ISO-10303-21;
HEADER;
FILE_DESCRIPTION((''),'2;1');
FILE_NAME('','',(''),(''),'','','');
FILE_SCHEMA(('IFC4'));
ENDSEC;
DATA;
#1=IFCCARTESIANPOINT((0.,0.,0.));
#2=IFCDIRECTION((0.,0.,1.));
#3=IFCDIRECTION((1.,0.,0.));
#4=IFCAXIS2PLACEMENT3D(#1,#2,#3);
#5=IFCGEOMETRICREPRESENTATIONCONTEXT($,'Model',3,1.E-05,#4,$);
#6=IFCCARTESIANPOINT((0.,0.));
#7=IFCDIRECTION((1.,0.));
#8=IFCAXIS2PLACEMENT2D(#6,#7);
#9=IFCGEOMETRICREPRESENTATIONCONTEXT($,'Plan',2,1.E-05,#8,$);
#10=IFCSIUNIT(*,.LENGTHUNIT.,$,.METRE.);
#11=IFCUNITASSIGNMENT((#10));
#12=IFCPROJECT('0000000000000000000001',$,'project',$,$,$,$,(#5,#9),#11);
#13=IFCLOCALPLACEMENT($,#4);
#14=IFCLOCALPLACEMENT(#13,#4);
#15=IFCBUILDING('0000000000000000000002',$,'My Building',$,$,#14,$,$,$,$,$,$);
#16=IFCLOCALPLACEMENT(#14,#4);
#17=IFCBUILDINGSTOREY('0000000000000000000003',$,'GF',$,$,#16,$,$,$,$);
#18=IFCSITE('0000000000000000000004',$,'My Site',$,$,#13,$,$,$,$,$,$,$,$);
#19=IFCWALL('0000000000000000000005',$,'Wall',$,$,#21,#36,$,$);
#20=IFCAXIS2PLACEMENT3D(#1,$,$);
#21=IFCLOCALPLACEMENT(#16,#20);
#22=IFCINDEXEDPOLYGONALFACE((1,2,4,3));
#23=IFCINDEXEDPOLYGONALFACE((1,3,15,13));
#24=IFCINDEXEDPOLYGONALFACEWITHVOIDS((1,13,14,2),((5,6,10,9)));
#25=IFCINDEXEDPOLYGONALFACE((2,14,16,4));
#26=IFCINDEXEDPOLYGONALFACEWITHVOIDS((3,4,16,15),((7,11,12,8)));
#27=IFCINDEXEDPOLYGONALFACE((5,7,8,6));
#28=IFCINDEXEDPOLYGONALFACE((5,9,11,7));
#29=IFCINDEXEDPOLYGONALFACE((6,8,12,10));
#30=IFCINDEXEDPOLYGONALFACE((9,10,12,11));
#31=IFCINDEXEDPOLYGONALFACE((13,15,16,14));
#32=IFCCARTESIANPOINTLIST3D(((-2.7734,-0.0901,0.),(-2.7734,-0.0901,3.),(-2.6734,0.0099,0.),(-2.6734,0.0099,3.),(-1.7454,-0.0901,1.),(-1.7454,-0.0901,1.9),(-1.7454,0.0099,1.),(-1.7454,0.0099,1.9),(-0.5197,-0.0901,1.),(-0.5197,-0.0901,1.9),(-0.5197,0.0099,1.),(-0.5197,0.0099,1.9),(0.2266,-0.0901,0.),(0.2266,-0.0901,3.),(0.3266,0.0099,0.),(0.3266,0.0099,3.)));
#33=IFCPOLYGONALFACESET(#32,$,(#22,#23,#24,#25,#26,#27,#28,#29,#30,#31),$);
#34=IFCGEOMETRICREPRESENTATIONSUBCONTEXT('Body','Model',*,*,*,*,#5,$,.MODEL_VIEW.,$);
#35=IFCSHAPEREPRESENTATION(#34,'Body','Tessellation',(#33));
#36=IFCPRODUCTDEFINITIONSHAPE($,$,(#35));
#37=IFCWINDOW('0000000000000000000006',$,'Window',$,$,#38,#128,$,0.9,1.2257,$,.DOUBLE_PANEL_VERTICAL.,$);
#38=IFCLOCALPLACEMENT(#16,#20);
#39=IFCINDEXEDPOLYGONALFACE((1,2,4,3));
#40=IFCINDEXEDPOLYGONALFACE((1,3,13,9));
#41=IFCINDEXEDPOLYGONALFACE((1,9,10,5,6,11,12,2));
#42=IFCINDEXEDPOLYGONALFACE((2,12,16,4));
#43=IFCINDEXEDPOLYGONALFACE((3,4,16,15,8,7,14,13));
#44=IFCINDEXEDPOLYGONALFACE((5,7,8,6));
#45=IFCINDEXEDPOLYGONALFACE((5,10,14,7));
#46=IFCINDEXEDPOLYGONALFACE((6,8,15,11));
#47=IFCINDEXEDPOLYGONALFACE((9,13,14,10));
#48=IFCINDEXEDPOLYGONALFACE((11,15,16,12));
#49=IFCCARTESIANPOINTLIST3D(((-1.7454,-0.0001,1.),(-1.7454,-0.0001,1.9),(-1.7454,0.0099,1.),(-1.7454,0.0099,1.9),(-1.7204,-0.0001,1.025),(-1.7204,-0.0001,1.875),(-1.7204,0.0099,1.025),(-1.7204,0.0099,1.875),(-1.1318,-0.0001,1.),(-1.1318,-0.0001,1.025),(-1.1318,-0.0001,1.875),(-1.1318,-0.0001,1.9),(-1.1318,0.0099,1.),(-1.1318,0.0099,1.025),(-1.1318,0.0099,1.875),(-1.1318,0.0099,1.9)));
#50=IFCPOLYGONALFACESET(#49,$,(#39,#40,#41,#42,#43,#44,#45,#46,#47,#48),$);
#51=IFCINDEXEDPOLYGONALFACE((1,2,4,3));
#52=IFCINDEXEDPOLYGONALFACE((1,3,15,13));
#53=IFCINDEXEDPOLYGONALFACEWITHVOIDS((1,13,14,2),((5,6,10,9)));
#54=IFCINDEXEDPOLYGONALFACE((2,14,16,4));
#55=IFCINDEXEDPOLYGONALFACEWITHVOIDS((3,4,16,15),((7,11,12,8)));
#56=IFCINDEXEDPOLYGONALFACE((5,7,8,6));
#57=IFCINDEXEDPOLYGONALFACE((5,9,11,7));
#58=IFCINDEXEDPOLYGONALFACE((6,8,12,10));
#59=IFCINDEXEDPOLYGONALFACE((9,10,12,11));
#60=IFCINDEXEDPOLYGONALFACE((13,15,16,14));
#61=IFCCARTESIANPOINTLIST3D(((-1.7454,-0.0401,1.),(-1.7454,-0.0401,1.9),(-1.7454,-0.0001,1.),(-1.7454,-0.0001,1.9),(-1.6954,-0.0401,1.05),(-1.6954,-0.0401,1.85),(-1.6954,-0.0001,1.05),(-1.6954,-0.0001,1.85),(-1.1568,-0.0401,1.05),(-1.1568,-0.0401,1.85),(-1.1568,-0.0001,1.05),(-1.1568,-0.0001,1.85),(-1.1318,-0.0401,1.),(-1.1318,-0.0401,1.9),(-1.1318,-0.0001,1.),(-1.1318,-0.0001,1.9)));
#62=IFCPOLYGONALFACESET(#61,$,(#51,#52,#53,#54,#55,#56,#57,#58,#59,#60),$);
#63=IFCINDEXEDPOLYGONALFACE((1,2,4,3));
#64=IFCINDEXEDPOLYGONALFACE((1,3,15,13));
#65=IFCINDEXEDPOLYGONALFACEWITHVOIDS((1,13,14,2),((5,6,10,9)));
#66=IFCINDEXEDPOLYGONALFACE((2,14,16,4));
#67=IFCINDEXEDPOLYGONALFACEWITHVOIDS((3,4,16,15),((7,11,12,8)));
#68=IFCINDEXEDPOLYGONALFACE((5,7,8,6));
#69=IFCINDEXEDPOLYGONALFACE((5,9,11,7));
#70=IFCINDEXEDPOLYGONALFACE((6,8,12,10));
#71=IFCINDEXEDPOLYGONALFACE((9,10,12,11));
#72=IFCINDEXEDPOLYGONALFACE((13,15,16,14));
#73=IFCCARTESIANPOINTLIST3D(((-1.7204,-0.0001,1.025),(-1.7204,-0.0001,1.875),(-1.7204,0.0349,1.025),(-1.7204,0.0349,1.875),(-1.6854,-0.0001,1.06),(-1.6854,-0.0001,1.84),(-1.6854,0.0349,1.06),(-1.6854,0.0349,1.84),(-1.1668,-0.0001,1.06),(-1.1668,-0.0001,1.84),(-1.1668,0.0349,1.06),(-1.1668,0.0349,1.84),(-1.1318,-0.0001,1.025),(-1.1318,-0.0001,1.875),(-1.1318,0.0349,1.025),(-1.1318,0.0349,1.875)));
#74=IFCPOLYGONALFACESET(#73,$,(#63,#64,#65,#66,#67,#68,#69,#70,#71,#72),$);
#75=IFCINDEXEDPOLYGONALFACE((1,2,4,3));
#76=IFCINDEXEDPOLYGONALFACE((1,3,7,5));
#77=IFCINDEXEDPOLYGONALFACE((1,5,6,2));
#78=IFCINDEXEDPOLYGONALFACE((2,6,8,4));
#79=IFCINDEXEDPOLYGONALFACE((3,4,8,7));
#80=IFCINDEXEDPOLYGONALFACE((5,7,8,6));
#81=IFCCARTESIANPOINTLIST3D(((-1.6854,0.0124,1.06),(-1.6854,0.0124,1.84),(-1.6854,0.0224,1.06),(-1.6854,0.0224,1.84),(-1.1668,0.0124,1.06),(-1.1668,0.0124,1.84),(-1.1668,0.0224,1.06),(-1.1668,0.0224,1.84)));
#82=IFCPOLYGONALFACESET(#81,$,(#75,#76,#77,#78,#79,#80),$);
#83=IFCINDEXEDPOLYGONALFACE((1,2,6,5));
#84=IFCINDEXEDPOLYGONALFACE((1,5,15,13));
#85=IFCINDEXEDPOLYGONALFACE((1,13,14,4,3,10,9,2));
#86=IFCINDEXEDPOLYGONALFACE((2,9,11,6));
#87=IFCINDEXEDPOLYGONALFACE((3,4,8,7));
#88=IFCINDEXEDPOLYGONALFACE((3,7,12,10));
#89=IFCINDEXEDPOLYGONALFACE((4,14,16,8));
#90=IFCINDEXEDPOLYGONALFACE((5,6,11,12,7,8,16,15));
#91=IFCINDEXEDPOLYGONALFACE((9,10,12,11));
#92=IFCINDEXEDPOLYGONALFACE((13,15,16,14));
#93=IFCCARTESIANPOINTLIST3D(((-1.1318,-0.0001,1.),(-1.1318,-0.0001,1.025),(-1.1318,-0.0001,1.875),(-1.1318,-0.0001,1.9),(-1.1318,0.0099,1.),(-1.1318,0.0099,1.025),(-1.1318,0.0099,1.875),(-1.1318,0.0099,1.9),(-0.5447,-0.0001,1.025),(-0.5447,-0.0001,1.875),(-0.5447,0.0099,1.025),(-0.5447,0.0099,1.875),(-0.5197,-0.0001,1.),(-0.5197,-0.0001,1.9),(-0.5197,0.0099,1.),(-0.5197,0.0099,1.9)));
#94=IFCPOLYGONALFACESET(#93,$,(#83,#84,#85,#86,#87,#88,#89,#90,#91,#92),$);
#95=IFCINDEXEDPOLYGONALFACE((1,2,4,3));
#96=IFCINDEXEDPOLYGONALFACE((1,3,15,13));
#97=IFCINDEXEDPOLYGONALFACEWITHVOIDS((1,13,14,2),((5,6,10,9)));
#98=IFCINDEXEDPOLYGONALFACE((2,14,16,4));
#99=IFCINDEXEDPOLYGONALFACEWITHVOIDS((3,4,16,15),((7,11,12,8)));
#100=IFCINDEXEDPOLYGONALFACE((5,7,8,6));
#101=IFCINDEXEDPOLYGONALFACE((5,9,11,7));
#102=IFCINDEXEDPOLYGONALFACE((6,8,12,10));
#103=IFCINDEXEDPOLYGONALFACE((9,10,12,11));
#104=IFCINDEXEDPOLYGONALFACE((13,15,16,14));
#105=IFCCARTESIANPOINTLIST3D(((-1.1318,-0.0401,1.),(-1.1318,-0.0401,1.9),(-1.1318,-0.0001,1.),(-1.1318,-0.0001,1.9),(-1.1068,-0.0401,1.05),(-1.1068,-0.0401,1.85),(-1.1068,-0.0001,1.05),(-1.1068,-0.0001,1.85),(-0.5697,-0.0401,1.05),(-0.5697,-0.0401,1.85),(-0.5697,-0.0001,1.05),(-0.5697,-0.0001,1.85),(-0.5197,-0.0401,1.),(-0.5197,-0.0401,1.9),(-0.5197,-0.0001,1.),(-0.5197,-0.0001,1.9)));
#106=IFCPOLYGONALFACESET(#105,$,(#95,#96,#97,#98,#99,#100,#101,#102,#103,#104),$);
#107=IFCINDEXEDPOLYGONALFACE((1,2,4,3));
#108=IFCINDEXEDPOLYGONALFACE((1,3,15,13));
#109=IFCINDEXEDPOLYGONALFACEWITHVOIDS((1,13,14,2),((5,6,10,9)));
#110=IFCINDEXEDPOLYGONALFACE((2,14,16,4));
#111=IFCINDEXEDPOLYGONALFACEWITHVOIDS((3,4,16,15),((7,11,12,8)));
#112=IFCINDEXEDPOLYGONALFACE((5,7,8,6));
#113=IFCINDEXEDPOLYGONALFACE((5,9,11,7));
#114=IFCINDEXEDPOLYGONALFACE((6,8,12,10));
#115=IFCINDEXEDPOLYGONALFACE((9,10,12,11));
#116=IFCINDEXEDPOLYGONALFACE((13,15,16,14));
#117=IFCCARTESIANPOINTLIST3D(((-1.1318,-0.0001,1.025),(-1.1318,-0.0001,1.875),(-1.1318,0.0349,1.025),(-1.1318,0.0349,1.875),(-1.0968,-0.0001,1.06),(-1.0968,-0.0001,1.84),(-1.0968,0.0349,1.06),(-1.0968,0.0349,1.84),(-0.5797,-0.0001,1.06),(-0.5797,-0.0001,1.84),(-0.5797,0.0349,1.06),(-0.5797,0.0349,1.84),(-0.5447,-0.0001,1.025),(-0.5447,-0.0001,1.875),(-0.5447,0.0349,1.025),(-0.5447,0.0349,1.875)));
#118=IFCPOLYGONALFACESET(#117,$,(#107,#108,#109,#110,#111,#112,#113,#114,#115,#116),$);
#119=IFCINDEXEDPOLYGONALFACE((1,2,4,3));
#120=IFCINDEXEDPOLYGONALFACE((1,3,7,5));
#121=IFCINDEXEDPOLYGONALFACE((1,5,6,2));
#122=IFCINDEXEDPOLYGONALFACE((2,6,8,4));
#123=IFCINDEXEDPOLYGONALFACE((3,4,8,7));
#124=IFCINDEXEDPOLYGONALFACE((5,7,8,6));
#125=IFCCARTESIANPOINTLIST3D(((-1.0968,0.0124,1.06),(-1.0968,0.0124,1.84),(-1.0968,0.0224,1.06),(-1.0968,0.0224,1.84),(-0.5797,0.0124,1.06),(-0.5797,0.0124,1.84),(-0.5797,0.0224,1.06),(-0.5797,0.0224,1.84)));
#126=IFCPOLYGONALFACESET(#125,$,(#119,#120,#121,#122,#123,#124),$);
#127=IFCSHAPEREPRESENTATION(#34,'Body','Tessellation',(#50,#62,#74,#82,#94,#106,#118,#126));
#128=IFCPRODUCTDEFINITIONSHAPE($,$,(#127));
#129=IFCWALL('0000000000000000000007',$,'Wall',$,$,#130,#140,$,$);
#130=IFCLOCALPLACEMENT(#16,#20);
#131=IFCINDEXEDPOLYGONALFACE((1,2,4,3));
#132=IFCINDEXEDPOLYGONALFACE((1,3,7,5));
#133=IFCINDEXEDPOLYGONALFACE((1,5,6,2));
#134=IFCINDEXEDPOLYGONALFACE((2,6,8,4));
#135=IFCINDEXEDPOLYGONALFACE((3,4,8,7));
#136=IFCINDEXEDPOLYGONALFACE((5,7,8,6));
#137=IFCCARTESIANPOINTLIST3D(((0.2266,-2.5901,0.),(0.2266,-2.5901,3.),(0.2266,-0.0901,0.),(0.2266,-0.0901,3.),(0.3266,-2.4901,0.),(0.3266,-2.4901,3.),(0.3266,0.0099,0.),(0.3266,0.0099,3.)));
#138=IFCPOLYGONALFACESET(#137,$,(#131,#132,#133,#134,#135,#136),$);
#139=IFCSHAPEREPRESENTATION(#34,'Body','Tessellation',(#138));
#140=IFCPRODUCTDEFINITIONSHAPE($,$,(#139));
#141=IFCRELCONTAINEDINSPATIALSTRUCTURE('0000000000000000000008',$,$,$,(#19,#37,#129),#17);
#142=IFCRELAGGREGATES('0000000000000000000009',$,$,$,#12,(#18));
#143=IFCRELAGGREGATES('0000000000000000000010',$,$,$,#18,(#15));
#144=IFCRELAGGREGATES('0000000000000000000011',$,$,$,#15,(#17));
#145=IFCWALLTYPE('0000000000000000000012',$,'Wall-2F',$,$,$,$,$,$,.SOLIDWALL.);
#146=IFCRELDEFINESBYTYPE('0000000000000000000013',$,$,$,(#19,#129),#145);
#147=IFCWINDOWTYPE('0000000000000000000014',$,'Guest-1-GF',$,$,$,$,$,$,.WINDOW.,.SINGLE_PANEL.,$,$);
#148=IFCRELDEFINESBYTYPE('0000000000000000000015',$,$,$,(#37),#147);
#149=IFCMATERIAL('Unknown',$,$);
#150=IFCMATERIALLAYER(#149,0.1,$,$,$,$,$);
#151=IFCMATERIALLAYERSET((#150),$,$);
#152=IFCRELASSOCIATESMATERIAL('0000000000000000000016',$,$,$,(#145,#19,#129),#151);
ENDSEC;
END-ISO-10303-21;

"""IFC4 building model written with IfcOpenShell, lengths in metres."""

from ifc_helpers import new_model, entity, si_unit, frame, origin_with_axes, origin_2d_with_axis, place, context, subcontext, project, spatial, line, indexed_curve, outline, extrude, shape, source, transform, mapped, material, layer, layer_set, layer_usage, type_object, type_shapes, element, fill, save


model = new_model("IFC4")

# Units and contexts
model_context = context("Model", 3, precision=1e-05, world=origin_with_axes())
plan_context = context("Plan", 2, precision=1e-05, world=origin_2d_with_axis())
body_context_1 = subcontext(model_context, "Body", "Model", "MODEL_VIEW")
body_context_2 = subcontext(plan_context, "Body", "Plan", "PLAN_VIEW")
ifc_project = project(units=[si_unit("LENGTHUNIT", "METRE")], contexts=[model_context, plan_context])

# Site, building, storey
site_placement = place(None, origin_with_axes())
site = spatial("IfcSite", under=ifc_project, at=site_placement, Name="My Site")
building_placement = place(site_placement, origin_with_axes())
building = spatial("IfcBuilding", under=site, at=building_placement, Name="My Building")
storey_placement = place(building_placement, origin_with_axes())
storey = spatial("IfcBuildingStorey", under=building, at=storey_placement, Name="GF")

# Shared definitions
ifc_material = material(Name="Unknown")

# Shared definitions
ifc_layer_1 = layer(ifc_material, 0.1)
ifc_layer_set_1 = layer_set([ifc_layer_1])
wall_type = type_object("IfcWallType", Name="Wall-2F", PredefinedType="SOLIDWALL", material=ifc_layer_set_1)

# Wall, opening, window
ifc_layer_usage_1 = layer_usage(ifc_layer_set_1, "AXIS2", "POSITIVE", 0.0)
wall_1_placement = place(storey_placement, frame((-2.7734, -0.0901, 0.0), z_axis=(0.0, 0.0, 1.0), x_axis=(1.0, 0.0, 0.0)))
wall_1 = element("IfcWall", 1, at=wall_1_placement, inside=storey, type_object=wall_type, material=ifc_layer_usage_1, Name="Wall", context=body_context_1, shape_type="SweptSolid", body=[
    extrude(outline(indexed_curve([(0.0, 0.0), (0.1, 0.1), (3.1, 0.1), (3.0, 0.0)], segments=[line(1, 2, 3, 4, 1)])), origin_with_axes(), (0.0, 0.0, 1.0), 3.0),
])
shared_shape_1 = source(origin_with_axes(), body_context_1, "Body", "SweptSolid", [
    extrude(outline(indexed_curve([(0.0, 0.0), (1.2257, 0.0), (1.2257, 0.9), (0.0, 0.9)], segments=[line(1, 2, 3, 4, 1)])), frame((0.0, -0.6, 0.0), z_axis=(0.0, -1.0, 0.0), x_axis=(1.0, 0.0, 0.0)), (0.0, 0.0, -1.0), 1.2),
])
opening_1_placement = place(wall_1_placement, frame((1.028, 0.0, 1.0), z_axis=(0.0, 0.0, 1.0), x_axis=(1.0, -0.000001, 0.0)))
opening_1 = element("IfcOpeningElement", 2, at=opening_1_placement, cuts=wall_1, PredefinedType="OPENING", context=body_context_1, shape_type="MappedRepresentation", body=[
    mapped(shared_shape_1, transform((0.0, 0.0, 0.0), x_axis=(1.0, 0.0, 0.0), y_axis=(0.0, 1.0, 0.0), z_axis=(0.0, 0.0, 1.0), scale=1.0)),
])
window_type_1 = type_object("IfcWindowType", Name="Guest-1-GF", PartitioningType="SINGLE_PANEL", PredefinedType="WINDOW")
shared_shape_2 = source(origin_with_axes(), body_context_1, "Body", "SweptSolid", [
    extrude(outline(indexed_curve([(0.6136, 0.0), (0.0, 0.0), (0.0, 0.9), (0.6136, 0.9), (0.6136, 0.875), (0.025, 0.875), (0.025, 0.025), (0.6136, 0.025)], segments=[line(1, 2, 3, 4, 5, 6, 7, 8, 1)])), frame((0.0, 0.09, 0.0), z_axis=(0.0, -1.0, 0.0), x_axis=(1.0, 0.0, 0.0)), (0.0, 0.0, -1.0), 0.01),
    extrude(outline(indexed_curve([(0.0, 0.0), (0.6136, 0.0), (0.6136, 0.9), (0.0, 0.9)], segments=[line(1, 2, 3, 4, 1)]), holes=[indexed_curve([(0.05, 0.05), (0.5886, 0.05), (0.5886, 0.85), (0.05, 0.85)], segments=[line(1, 2, 3, 4, 1)])]), frame((0.0, 0.05, 0.0), z_axis=(0.0, -1.0, 0.0), x_axis=(1.0, 0.0, 0.0)), (0.0, 0.0, -1.0), 0.04),
    extrude(outline(indexed_curve([(0.0, 0.0), (0.5886, 0.0), (0.5886, 0.85), (0.0, 0.85)], segments=[line(1, 2, 3, 4, 1)]), holes=[indexed_curve([(0.035, 0.035), (0.5536, 0.035), (0.5536, 0.815), (0.035, 0.815)], segments=[line(1, 2, 3, 4, 1)])]), frame((0.025, 0.09, 0.025), z_axis=(0.0, -1.0, 0.0), x_axis=(1.0, 0.0, 0.0)), (0.0, 0.0, -1.0), 0.035),
    extrude(outline(indexed_curve([(0.035, 0.035), (0.5536, 0.035), (0.5536, 0.815), (0.035, 0.815)], segments=[line(1, 2, 3, 4, 1)])), frame((0.025, 0.1025, 0.025), z_axis=(0.0, -1.0, 0.0), x_axis=(1.0, 0.0, 0.0)), (0.0, 0.0, -1.0), 0.01),
    extrude(outline(indexed_curve([(0.0, 0.9), (0.6121, 0.9), (0.6121, 0.0), (0.0, 0.0), (0.0, 0.025), (0.5871, 0.025), (0.5871, 0.875), (0.0, 0.875)], segments=[line(1, 2, 3, 4, 5, 6, 7, 8, 1)])), frame((0.6136, 0.09, 0.0), z_axis=(0.0, -1.0, 0.0), x_axis=(1.0, 0.0, 0.0)), (0.0, 0.0, -1.0), 0.01),
    extrude(outline(indexed_curve([(0.0, 0.0), (0.6121, 0.0), (0.6121, 0.9), (0.0, 0.9)], segments=[line(1, 2, 3, 4, 1)]), holes=[indexed_curve([(0.025, 0.05), (0.5621, 0.05), (0.5621, 0.85), (0.025, 0.85)], segments=[line(1, 2, 3, 4, 1)])]), frame((0.6136, 0.05, 0.0), z_axis=(0.0, -1.0, 0.0), x_axis=(1.0, 0.0, 0.0)), (0.0, 0.0, -1.0), 0.04),
    extrude(outline(indexed_curve([(0.0, 0.0), (0.5871, 0.0), (0.5871, 0.85), (0.0, 0.85)], segments=[line(1, 2, 3, 4, 1)]), holes=[indexed_curve([(0.035, 0.035), (0.5521, 0.035), (0.5521, 0.815), (0.035, 0.815)], segments=[line(1, 2, 3, 4, 1)])]), frame((0.6136, 0.09, 0.025), z_axis=(0.0, -1.0, 0.0), x_axis=(1.0, 0.0, 0.0)), (0.0, 0.0, -1.0), 0.035),
    extrude(outline(indexed_curve([(0.035, 0.035), (0.5521, 0.035), (0.5521, 0.815), (0.035, 0.815)], segments=[line(1, 2, 3, 4, 1)])), frame((0.6136, 0.1025, 0.025), z_axis=(0.0, -1.0, 0.0), x_axis=(1.0, 0.0, 0.0)), (0.0, 0.0, -1.0), 0.01),
])
shared_shape_3 = source(origin_with_axes(), body_context_2, "Body", "Curve2D", [
    entity("IfcIndexedPolyCurve", entity("IfcCartesianPointList2D", [[0.05, 0.05], [0.5886, 0.05]])),
    entity("IfcIndexedPolyCurve", entity("IfcCartesianPointList2D", [[0.0, 0.1], [0.025, 0.1], [0.025, 0.09], [0.05, 0.09], [0.05, 0.05], [0.0, 0.05]]), [entity("IfcLineIndex", [1, 2, 3, 4, 5, 6, 1])]),
    entity("IfcIndexedPolyCurve", entity("IfcCartesianPointList2D", [[0.6136, 0.1], [0.6136, 0.1], [0.6136, 0.09], [0.5886, 0.09], [0.5886, 0.05], [0.6136, 0.05]])),
    entity("IfcIndexedPolyCurve", entity("IfcCartesianPointList2D", [[0.025, 0.09], [0.06, 0.09], [0.06, 0.125], [0.025, 0.125]]), [entity("IfcLineIndex", [1, 2, 3, 4, 1])]),
    entity("IfcIndexedPolyCurve", entity("IfcCartesianPointList2D", [[0.6136, 0.09], [0.5786, 0.09], [0.5786, 0.125], [0.6136, 0.125]]), [entity("IfcLineIndex", [1, 2, 3, 4, 1])]),
    entity("IfcIndexedPolyCurve", entity("IfcCartesianPointList2D", [[0.06, 0.09], [0.5786, 0.09]])),
    entity("IfcIndexedPolyCurve", entity("IfcCartesianPointList2D", [[0.06, 0.125], [0.5786, 0.125]])),
    entity("IfcIndexedPolyCurve", entity("IfcCartesianPointList2D", [[0.06, 0.1075], [0.5786, 0.1075]])),
    entity("IfcIndexedPolyCurve", entity("IfcCartesianPointList2D", [[0.6386, 0.05], [1.1757, 0.05]])),
    entity("IfcIndexedPolyCurve", entity("IfcCartesianPointList2D", [[0.6136, 0.1], [0.6136, 0.1], [0.6136, 0.09], [0.6386, 0.09], [0.6386, 0.05], [0.6136, 0.05]])),
    entity("IfcIndexedPolyCurve", entity("IfcCartesianPointList2D", [[1.2257, 0.1], [1.2007, 0.1], [1.2007, 0.09], [1.1757, 0.09], [1.1757, 0.05], [1.2257, 0.05]]), [entity("IfcLineIndex", [1, 2, 3, 4, 5, 6, 1])]),
    entity("IfcIndexedPolyCurve", entity("IfcCartesianPointList2D", [[0.6136, 0.09], [0.6486, 0.09], [0.6486, 0.125], [0.6136, 0.125]]), [entity("IfcLineIndex", [1, 2, 3, 4, 1])]),
    entity("IfcIndexedPolyCurve", entity("IfcCartesianPointList2D", [[1.2007, 0.09], [1.1657, 0.09], [1.1657, 0.125], [1.2007, 0.125]]), [entity("IfcLineIndex", [1, 2, 3, 4, 1])]),
    entity("IfcIndexedPolyCurve", entity("IfcCartesianPointList2D", [[0.6486, 0.09], [1.1657, 0.09]])),
    entity("IfcIndexedPolyCurve", entity("IfcCartesianPointList2D", [[0.6486, 0.125], [1.1657, 0.125]])),
    entity("IfcIndexedPolyCurve", entity("IfcCartesianPointList2D", [[0.6486, 0.1075], [1.1657, 0.1075]])),
])
type_shapes(window_type_1, [shared_shape_2, shared_shape_3])
window_1_placement = place(opening_1_placement, frame((0.0, 0.0, 0.0), z_axis=(0.0, 0.0, 1.0), x_axis=(1.0, 0.0, 0.0)))
window_1 = element("IfcWindow", 3, at=window_1_placement, inside=storey, type_object=window_type_1, Name="Window", OverallHeight=0.9, OverallWidth=1.2257, PartitioningType="DOUBLE_PANEL_VERTICAL", shapes=[
    shape(body_context_1, "Body", "MappedRepresentation", [mapped(shared_shape_2, transform((0.0, 0.0, 0.0), x_axis=(1.0, 0.0, 0.0), y_axis=(0.0, 1.0, 0.0), z_axis=(0.0, 0.0, 1.0), scale=1.0))]),
    shape(body_context_2, "Body", "MappedRepresentation", [mapped(shared_shape_3, transform((0.0, 0.0, 0.0), x_axis=(1.0, 0.0, 0.0), y_axis=(0.0, 1.0, 0.0), z_axis=(0.0, 0.0, 1.0), scale=1.0))]),
])
fill(opening_1, window_1)

# Wall
ifc_layer_usage_2 = layer_usage(ifc_layer_set_1, "AXIS2", "POSITIVE", 0.0)
wall_2_placement = place(storey_placement, frame((0.2266, -0.0901, 0.0), z_axis=(0.0, 0.0, 1.0), x_axis=(0.0, -1.0, 0.0)))
element("IfcWall", 4, at=wall_2_placement, inside=storey, type_object=wall_type, material=ifc_layer_usage_2, Name="Wall", context=body_context_1, shape_type="SweptSolid", body=[
    extrude(outline(indexed_curve([(0.0, 0.0), (-0.1, 0.1), (2.4, 0.1), (2.5, 0.0)], segments=[line(1, 2, 3, 4, 1)])), origin_with_axes(), (0.0, 0.0, 1.0), 3.0),
])

save(model, "model.ifc")
